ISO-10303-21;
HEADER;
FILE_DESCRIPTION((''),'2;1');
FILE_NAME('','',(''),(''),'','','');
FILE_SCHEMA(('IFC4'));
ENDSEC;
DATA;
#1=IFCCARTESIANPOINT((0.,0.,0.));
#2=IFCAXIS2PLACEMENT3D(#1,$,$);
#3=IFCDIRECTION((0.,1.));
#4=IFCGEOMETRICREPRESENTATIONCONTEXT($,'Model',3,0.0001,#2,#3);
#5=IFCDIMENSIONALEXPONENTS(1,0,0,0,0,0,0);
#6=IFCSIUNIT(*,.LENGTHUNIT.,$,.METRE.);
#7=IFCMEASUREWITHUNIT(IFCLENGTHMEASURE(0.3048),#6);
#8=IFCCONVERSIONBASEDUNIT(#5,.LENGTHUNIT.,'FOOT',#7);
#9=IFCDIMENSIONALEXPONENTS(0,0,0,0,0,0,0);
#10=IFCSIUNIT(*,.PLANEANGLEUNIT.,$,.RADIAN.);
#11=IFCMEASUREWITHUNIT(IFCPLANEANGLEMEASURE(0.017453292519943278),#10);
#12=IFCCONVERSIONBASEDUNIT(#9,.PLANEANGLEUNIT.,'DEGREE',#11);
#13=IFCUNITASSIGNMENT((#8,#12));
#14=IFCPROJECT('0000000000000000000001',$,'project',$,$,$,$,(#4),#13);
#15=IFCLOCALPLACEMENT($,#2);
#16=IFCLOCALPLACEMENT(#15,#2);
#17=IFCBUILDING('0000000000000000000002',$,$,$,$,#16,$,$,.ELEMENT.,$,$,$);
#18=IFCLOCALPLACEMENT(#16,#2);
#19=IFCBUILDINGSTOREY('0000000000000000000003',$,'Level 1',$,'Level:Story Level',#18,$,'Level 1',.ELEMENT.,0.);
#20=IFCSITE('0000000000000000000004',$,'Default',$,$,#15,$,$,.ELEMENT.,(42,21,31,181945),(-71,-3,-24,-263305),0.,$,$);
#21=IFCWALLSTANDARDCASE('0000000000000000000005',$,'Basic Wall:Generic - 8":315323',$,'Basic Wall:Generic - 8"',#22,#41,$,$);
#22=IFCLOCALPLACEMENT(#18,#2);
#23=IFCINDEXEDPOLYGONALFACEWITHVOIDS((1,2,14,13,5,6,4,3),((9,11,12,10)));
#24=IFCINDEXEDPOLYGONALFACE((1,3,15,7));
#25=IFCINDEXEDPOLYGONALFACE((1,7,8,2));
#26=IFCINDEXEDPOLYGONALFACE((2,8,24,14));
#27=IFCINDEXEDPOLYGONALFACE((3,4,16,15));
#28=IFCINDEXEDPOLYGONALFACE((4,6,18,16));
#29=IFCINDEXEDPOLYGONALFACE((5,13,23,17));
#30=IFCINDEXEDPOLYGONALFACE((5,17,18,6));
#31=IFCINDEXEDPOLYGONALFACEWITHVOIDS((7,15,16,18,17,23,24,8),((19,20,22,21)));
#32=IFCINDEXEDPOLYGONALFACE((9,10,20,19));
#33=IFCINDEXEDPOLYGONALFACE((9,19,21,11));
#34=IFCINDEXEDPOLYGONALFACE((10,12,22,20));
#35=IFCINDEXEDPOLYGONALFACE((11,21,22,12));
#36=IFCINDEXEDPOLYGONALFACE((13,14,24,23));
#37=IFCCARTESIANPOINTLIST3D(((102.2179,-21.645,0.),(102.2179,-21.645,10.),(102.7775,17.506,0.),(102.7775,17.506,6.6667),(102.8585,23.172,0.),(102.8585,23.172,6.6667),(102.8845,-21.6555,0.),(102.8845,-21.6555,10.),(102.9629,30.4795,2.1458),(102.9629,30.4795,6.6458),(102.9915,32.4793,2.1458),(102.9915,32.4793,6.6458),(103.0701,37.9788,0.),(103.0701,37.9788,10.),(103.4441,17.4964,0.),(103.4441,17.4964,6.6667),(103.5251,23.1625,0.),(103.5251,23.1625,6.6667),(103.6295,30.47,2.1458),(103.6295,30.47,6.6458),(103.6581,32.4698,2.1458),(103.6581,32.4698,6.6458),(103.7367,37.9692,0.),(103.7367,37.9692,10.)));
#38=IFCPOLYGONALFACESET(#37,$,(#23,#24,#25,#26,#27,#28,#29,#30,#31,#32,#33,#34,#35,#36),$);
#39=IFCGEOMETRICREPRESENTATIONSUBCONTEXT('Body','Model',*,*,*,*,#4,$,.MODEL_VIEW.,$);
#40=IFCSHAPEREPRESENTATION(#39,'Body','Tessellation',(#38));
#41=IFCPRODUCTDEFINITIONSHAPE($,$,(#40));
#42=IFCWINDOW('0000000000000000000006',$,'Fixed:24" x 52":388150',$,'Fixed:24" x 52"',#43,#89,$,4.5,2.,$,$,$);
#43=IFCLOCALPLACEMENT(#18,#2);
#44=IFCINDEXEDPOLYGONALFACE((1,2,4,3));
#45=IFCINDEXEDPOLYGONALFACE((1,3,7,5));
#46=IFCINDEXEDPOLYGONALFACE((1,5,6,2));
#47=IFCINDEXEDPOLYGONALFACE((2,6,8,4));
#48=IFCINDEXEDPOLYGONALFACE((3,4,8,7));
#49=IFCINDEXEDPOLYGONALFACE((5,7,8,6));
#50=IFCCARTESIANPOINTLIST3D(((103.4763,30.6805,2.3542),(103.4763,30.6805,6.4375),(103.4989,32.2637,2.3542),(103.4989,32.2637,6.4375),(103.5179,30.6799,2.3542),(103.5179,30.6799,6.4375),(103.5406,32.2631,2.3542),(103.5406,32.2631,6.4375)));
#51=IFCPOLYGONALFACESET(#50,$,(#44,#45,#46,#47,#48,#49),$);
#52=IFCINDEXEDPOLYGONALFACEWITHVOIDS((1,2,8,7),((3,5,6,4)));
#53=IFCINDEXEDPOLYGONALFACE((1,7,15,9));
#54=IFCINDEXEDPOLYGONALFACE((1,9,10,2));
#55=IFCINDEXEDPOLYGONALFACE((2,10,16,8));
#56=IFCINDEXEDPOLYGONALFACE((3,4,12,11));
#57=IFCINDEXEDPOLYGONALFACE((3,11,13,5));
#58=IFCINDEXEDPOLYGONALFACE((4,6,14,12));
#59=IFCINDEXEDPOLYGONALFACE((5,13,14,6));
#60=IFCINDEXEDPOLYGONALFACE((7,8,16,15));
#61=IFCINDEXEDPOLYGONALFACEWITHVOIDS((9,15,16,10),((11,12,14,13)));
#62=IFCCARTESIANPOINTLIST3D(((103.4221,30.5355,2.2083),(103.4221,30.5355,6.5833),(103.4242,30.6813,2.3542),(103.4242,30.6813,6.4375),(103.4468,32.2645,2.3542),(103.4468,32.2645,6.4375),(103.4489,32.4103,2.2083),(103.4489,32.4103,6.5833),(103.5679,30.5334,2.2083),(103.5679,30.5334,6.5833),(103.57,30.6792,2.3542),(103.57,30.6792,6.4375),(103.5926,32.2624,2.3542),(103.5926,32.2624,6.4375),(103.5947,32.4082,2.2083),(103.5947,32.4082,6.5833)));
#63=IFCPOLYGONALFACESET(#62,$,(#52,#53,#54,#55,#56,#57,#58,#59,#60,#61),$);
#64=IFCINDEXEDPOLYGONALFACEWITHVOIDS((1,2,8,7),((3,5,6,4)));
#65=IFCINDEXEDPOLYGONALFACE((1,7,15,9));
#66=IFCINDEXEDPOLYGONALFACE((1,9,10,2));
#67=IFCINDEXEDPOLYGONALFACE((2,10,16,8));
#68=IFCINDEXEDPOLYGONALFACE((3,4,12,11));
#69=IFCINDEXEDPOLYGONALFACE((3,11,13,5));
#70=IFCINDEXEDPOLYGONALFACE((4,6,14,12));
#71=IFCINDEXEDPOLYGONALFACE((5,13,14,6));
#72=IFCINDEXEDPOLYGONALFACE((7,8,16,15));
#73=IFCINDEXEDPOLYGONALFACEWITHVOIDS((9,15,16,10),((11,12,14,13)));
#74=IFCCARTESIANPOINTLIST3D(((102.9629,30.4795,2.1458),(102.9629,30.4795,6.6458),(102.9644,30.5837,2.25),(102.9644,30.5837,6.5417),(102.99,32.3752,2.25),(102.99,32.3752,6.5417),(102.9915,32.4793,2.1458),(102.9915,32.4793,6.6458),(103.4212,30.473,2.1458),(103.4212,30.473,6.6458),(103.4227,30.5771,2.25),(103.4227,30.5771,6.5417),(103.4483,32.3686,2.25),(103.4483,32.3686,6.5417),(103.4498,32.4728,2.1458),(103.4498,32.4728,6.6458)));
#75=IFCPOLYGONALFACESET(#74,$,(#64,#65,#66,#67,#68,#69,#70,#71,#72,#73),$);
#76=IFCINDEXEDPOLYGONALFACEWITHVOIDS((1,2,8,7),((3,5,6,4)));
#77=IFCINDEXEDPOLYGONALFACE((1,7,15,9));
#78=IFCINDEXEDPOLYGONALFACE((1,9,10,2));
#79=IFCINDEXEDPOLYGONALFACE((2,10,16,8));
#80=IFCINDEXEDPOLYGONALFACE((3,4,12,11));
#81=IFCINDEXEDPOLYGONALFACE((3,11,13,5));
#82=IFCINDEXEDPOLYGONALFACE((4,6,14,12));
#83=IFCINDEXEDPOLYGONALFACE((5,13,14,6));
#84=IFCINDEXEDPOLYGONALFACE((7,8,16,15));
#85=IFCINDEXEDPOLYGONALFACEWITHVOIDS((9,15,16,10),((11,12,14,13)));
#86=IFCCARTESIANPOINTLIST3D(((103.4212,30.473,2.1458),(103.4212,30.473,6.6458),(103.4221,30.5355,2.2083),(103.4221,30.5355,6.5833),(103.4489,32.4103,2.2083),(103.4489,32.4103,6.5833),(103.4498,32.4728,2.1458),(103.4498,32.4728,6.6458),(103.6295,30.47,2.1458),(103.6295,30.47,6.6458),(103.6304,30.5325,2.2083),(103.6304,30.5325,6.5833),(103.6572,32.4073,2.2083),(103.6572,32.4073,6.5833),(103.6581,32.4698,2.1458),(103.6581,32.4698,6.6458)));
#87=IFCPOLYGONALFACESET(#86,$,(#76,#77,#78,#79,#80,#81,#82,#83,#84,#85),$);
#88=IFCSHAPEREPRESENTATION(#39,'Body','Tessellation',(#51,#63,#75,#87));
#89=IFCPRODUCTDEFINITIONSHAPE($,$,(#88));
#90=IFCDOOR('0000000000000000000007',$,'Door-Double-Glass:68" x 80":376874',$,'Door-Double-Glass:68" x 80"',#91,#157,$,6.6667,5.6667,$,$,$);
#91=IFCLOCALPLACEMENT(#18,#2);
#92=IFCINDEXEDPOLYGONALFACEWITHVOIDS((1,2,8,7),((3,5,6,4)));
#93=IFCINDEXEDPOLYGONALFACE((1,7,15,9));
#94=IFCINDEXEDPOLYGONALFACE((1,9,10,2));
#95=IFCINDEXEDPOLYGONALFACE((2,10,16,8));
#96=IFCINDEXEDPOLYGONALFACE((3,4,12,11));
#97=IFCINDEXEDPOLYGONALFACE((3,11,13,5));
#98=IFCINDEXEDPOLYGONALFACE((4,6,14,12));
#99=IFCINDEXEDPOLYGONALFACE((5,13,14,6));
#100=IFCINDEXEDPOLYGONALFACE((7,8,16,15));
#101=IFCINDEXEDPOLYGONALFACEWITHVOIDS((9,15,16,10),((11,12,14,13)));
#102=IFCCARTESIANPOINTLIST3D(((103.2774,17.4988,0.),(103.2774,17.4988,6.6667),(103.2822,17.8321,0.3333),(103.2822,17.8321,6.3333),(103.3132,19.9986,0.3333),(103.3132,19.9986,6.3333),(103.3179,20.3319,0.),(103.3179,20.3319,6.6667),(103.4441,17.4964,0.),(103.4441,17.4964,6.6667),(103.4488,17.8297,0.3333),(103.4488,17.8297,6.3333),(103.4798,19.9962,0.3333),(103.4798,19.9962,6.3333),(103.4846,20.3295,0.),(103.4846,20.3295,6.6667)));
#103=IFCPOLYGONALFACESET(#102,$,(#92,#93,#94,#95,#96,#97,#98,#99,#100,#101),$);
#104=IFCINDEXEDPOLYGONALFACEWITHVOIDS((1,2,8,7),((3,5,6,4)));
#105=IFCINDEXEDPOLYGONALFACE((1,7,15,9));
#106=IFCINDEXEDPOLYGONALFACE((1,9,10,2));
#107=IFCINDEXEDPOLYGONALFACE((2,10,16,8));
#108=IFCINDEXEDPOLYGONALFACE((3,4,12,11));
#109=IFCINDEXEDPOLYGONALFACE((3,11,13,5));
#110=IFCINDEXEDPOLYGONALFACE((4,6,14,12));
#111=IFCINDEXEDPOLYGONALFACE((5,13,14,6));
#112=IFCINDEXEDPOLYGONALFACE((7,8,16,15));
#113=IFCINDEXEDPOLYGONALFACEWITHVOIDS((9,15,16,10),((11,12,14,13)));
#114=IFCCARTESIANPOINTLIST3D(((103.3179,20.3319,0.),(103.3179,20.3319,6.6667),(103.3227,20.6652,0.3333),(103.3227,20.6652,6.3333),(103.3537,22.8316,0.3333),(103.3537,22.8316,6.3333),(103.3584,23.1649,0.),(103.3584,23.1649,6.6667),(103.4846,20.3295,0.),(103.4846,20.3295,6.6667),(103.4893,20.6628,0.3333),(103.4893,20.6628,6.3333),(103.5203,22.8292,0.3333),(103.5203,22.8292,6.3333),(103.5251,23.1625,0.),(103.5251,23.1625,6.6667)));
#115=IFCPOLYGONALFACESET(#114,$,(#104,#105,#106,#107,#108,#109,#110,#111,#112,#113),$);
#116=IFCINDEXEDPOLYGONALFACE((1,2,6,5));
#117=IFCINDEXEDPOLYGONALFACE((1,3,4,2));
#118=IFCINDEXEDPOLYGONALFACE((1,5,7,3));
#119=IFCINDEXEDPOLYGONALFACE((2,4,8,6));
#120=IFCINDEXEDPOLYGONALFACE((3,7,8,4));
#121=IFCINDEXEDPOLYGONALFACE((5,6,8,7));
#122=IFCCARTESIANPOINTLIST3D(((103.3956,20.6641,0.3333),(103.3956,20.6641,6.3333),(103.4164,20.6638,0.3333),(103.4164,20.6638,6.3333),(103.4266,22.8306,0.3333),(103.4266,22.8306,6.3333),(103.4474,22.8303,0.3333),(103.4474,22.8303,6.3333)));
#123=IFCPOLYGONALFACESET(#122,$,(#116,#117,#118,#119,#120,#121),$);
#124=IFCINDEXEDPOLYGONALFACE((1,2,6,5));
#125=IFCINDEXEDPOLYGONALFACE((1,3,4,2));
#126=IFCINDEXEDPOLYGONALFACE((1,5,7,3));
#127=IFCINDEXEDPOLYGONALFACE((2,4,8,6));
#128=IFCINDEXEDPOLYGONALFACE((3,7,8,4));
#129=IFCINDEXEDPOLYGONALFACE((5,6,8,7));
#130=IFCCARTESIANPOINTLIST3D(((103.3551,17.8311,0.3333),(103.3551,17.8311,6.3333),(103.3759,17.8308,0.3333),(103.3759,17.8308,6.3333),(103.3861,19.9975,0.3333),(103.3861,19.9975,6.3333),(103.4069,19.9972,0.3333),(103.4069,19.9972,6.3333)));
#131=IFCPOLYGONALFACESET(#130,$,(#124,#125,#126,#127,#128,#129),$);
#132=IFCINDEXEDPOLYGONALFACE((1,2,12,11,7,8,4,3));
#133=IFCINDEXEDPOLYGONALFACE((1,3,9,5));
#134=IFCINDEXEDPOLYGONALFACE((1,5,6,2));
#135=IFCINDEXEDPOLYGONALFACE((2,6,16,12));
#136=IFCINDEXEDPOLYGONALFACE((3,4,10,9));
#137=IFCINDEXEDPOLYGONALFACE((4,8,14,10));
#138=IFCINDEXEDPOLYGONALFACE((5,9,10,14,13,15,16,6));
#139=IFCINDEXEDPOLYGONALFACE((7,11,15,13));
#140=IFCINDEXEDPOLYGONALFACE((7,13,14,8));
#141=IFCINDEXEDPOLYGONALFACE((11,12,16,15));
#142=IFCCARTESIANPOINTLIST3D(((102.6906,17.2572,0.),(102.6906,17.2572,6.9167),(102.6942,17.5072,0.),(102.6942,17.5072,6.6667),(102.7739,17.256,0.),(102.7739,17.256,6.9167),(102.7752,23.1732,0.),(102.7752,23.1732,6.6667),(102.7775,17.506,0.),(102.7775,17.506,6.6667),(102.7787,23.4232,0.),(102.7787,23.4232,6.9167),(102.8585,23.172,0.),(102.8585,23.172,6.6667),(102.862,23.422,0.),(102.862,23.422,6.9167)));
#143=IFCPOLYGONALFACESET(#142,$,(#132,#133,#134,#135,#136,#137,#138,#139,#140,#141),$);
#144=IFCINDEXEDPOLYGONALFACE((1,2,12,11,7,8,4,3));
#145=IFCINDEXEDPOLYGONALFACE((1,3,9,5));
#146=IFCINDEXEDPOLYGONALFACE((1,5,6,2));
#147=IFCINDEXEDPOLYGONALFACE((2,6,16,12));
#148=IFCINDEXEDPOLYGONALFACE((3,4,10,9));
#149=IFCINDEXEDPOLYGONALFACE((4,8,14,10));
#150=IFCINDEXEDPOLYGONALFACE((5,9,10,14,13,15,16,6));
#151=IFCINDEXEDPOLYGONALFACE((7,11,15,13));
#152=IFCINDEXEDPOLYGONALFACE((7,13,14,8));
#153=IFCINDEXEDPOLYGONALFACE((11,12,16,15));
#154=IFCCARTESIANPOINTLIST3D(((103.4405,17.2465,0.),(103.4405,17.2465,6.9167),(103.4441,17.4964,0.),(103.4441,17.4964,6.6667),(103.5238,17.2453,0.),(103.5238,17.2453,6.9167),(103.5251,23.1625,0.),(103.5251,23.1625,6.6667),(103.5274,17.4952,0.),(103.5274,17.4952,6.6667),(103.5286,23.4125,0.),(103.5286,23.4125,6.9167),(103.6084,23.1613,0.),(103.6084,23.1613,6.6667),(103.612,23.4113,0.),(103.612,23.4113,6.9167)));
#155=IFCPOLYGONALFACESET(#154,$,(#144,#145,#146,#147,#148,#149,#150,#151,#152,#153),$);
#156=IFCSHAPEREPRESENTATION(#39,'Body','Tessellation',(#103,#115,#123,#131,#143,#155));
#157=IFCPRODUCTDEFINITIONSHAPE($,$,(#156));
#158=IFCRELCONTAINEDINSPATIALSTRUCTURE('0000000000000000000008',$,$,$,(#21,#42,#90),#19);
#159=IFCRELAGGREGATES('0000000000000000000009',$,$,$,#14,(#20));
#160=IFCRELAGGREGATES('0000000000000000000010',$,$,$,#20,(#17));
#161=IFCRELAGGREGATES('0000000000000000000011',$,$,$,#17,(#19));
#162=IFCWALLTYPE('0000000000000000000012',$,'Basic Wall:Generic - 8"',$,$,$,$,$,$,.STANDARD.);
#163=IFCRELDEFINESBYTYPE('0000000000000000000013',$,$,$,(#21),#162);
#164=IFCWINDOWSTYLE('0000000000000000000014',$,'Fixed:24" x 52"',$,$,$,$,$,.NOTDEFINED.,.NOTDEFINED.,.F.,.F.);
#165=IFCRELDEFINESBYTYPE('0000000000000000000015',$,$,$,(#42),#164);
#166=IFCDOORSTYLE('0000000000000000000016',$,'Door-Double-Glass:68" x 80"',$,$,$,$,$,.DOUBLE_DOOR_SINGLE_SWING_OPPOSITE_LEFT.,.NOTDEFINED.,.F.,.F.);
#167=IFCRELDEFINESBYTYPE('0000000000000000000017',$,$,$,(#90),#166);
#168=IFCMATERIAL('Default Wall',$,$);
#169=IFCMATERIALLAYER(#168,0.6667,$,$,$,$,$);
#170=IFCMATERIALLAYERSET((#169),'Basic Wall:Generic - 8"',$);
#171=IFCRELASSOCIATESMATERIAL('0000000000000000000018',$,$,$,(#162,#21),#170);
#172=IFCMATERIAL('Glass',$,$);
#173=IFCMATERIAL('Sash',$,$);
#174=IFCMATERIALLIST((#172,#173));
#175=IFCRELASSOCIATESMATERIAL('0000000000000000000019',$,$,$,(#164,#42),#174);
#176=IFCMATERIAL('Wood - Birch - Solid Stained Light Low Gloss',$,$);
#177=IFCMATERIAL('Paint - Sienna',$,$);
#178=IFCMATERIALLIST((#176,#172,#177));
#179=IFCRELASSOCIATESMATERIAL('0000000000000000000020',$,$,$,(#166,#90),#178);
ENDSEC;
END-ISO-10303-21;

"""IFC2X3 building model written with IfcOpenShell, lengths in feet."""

from ifc_helpers import new_model, entity, si_unit, converted_unit, direction, frame, frame_2d, origin, place, context, subcontext, project, spatial, polyline, rectangle, outline, extrude, source, transform, mapped, material, material_list, layer, layer_set, layer_usage, type_object, type_shapes, element, fill, save


model = new_model("IFC2X3")

# Units and contexts
model_context = context("Model", 3, precision=0.0001, world=origin(), true_north=direction((0.0, 1.0)))
body_context = subcontext(model_context, "Body", "Model", "MODEL_VIEW")
ifc_project = project(units=[converted_unit("LENGTHUNIT", "FOOT", entity("IfcLengthMeasure", 0.3048), si_unit("LENGTHUNIT", "METRE"), dimensions=[1, 0, 0, 0, 0, 0, 0]), converted_unit("PLANEANGLEUNIT", "DEGREE", entity("IfcPlaneAngleMeasure", 0.017453292519943278), si_unit("PLANEANGLEUNIT", "RADIAN"), dimensions=[0, 0, 0, 0, 0, 0, 0])], contexts=[model_context])

# Site, building, storey
site_placement = place(None, origin())
site = spatial("IfcSite", under=ifc_project, at=site_placement, Name="Default", CompositionType="ELEMENT", RefLatitude=(42, 21, 31, 181945), RefLongitude=(-71, -3, -24, -263305), RefElevation=0.0)
building_placement = place(site_placement, origin())
building = spatial("IfcBuilding", under=site, at=building_placement, CompositionType="ELEMENT")
storey_placement = place(building_placement, origin())
storey = spatial("IfcBuildingStorey", under=building, at=storey_placement, Name="Level 1", ObjectType="Level:Story Level", LongName="Level 1", CompositionType="ELEMENT", Elevation=0.0)

# Shared definitions
ifc_material_1 = material(Name="Default Wall")
ifc_layer = layer(ifc_material_1, 0.6667)
ifc_layer_set = layer_set([ifc_layer], Name="Basic Wall:Generic - 8\"")
wall_type = type_object("IfcWallType", Name="Basic Wall:Generic - 8\"", PredefinedType="STANDARD", material=ifc_layer_set)
ifc_material_2 = material(Name="Glass")
ifc_material_3 = material(Name="Sash")
ifc_material_list_1 = material_list([ifc_material_2, ifc_material_3])
window_style_1 = type_object("IfcWindowStyle", Name="Fixed:24\" x 52\"", ConstructionType="NOTDEFINED", OperationType="NOTDEFINED", ParameterTakesPrecedence=False, Sizeable=False, material=ifc_material_list_1)
shared_shape_1 = source(origin(), body_context, "Body", "SweptSolid", [
    extrude(rectangle(XDim=0.0417, YDim=1.5833, at=frame_2d((0.0, 0.0), x_axis=(1.0, 0.0))), frame((1.0, 0.5312, 0.2083), z_axis=(0.0, 0.0, 1.0), x_axis=(0.0, 1.0, 0.0)), (0.0, 0.0, 1.0), 4.0833),
    extrude(outline(polyline([(-0.9375, -2.1875), (0.9375, -2.1875), (0.9375, 2.1875), (-0.9375, 2.1875), (-0.9375, -2.1875)]), holes=[polyline([(-0.7917, -2.0417), (-0.7917, 2.0417), (0.7917, 2.0417), (0.7917, -2.0417), (-0.7917, -2.0417)])]), frame((1.0, 0.4583, 2.25), z_axis=(0.0, 1.0, 0.0), x_axis=(1.0, 0.0, 0.0)), (0.0, 0.0, 1.0), 0.1458),
    extrude(outline(polyline([(-1.0, -2.25), (1.0, -2.25), (1.0, 2.25), (-1.0, 2.25), (-1.0, -2.25)]), holes=[polyline([(-0.8958, -2.1458), (-0.8958, 2.1458), (0.8958, 2.1458), (0.8958, -2.1458), (-0.8958, -2.1458)])]), frame((1.0, 0.0, 2.25), z_axis=(0.0, 1.0, 0.0), x_axis=(1.0, 0.0, 0.0)), (0.0, 0.0, 1.0), 0.4583),
    extrude(outline(polyline([(-2.25, -1.0), (2.25, -1.0), (2.25, 1.0), (-2.25, 1.0), (-2.25, -1.0)]), holes=[polyline([(-2.1875, -0.9375), (-2.1875, 0.9375), (2.1875, 0.9375), (2.1875, -0.9375), (-2.1875, -0.9375)])]), frame((1.0, 0.4583, 2.25), z_axis=(0.0, 1.0, 0.0), x_axis=(0.0, 0.0, -1.0)), (0.0, 0.0, 1.0), 0.2083),
])
type_shapes(window_style_1, [shared_shape_1])

# Wall, openings, window, door
ifc_layer_usage_1 = layer_usage(ifc_layer_set, "AXIS2", "NEGATIVE", 0.3333)
wall_1_placement = place(storey_placement, frame((103.4034, 37.974, 0.0), z_axis=(0.0, 0.0, 1.0), x_axis=(-0.014292, -0.999898, 0.0)))
wall_1 = element("IfcWallStandardCase", 1, at=wall_1_placement, inside=storey, type_object=wall_type, material=ifc_layer_usage_1, Name="Basic Wall:Generic - 8\":315323", ObjectType="Basic Wall:Generic - 8\"", context=body_context, shape_type="SweptSolid", body=[
    extrude(outline(polyline([(0.0, -0.3333), (0.6667, -0.3333), (59.6299, -0.3333), (59.6308, 0.3333), (0.0, 0.3333), (0.0, -0.3333)])), origin(), (0.0, 0.0, 1.0), 10.0),
])
opening_1_placement = place(wall_1_placement, frame((14.8082, -0.3333, 0.0)))
opening_1 = element("IfcOpeningElement", 2, at=opening_1_placement, cuts=wall_1, ObjectType="Opening", context=body_context, shape_type="SweptSolid", body=[
    extrude(rectangle(XDim=5.6667, YDim=6.6667, at=frame_2d((3.3333, 2.8333), x_axis=(0.0, 1.0))), frame((0.0, 0.0, 0.0), z_axis=(0.0, 1.0, 0.0), x_axis=(0.0, 0.0, 1.0)), (0.0, 0.0, 1.0), 0.6667),
])
opening_2_placement = place(wall_1_placement, frame((5.5, -0.3333, 2.1458)))
opening_2 = element("IfcOpeningElement", 3, at=opening_2_placement, cuts=wall_1, ObjectType="Opening", context=body_context, shape_type="SweptSolid", body=[
    extrude(rectangle(XDim=4.5, YDim=2.0, at=frame_2d((2.25, 1.0), x_axis=(-1.0, 0.0))), frame((0.0, 0.0, 0.0), z_axis=(0.0, 1.0, 0.0), x_axis=(0.0, 0.0, 1.0)), (0.0, 0.0, 1.0), 0.6667),
])
window_1_placement = place(opening_2_placement, origin())
window_1 = element("IfcWindow", 4, at=window_1_placement, inside=storey, type_object=window_style_1, material=ifc_material_list_1, Name="Fixed:24\" x 52\":388150", ObjectType="Fixed:24\" x 52\"", OverallHeight=4.5, OverallWidth=2.0, context=body_context, shape_type="MappedRepresentation", body=[
    mapped(shared_shape_1, transform((0.0, 0.0, 0.0), scale=1.0)),
])
fill(opening_2, window_1)
ifc_material_4 = material(Name="Wood - Birch - Solid Stained Light Low Gloss")
ifc_material_5 = material(Name="Paint - Sienna")
ifc_material_list_2 = material_list([ifc_material_4, ifc_material_2, ifc_material_5])
door_style = type_object("IfcDoorStyle", Name="Door-Double-Glass:68\" x 80\"", ConstructionType="NOTDEFINED", OperationType="DOUBLE_DOOR_SINGLE_SWING_OPPOSITE_LEFT", ParameterTakesPrecedence=False, Sizeable=False, material=ifc_material_list_2)
shared_shape_2 = source(origin(), body_context, "Body", "SweptSolid", [
    extrude(outline(polyline([(-3.3333, -1.4167), (3.3333, -1.4167), (3.3333, 1.4167), (-3.3333, 1.4167), (-3.3333, -1.4167)]), holes=[polyline([(-3.0, -1.0833), (-3.0, 1.0833), (3.0, 1.0833), (3.0, -1.0833), (-3.0, -1.0833)])]), frame((4.25, 0.5, 3.3333), z_axis=(0.0, 1.0, 0.0), x_axis=(0.0, 0.0, -1.0)), (0.0, 0.0, 1.0), 0.1667),
    extrude(outline(polyline([(-1.4167, -3.3333), (1.4167, -3.3333), (1.4167, 3.3333), (-1.4167, 3.3333), (-1.4167, -3.3333)]), holes=[polyline([(-1.0833, -3.0), (-1.0833, 3.0), (1.0833, 3.0), (1.0833, -3.0), (-1.0833, -3.0)])]), frame((1.4167, 0.5, 3.3333), z_axis=(0.0, 1.0, 0.0), x_axis=(1.0, 0.0, 0.0)), (0.0, 0.0, 1.0), 0.1667),
    extrude(rectangle(XDim=0.0208, YDim=2.1667, at=frame_2d((0.0, 0.0), x_axis=(1.0, 0.0))), frame((1.4167, 0.5833, 0.3333), z_axis=(0.0, 0.0, 1.0), x_axis=(0.0, -1.0, 0.0)), (0.0, 0.0, 1.0), 6.0),
    extrude(rectangle(XDim=0.0208, YDim=2.1667, at=frame_2d((0.0, 0.0), x_axis=(1.0, 0.0))), frame((4.25, 0.5833, 0.3333), z_axis=(0.0, 0.0, 1.0), x_axis=(0.0, -1.0, 0.0)), (0.0, 0.0, 1.0), 6.0),
    extrude(outline(polyline([(-3.0833, -3.3958), (-2.8333, -3.3958), (-2.8333, 3.2708), (2.8333, 3.2708), (2.8333, -3.3958), (3.0833, -3.3958), (3.0833, 3.5208), (-3.0833, 3.5208), (-3.0833, -3.3958)])), frame((2.8333, -0.0833, 3.3958), z_axis=(0.0, 1.0, 0.0), x_axis=(-1.0, 0.0, 0.0)), (0.0, 0.0, 1.0), 0.0833),
    extrude(outline(polyline([(-3.0833, -3.3958), (-2.8333, -3.3958), (-2.8333, 3.2708), (2.8333, 3.2708), (2.8333, -3.3958), (3.0833, -3.3958), (3.0833, 3.5208), (-3.0833, 3.5208), (-3.0833, -3.3958)])), frame((2.8333, 0.6667, 3.3958), z_axis=(0.0, 1.0, 0.0), x_axis=(-1.0, 0.0, 0.0)), (0.0, 0.0, 1.0), 0.0833),
])
type_shapes(door_style, [shared_shape_2])
door_placement = place(opening_1_placement, origin())
door = element("IfcDoor", 5, at=door_placement, inside=storey, type_object=door_style, material=ifc_material_list_2, Name="Door-Double-Glass:68\" x 80\":376874", ObjectType="Door-Double-Glass:68\" x 80\"", OverallHeight=6.6667, OverallWidth=5.6667, context=body_context, shape_type="MappedRepresentation", body=[
    mapped(shared_shape_2, transform((0.0, 0.0, 0.0), scale=1.0)),
])
fill(opening_1, door)

save(model, "model.ifc")
